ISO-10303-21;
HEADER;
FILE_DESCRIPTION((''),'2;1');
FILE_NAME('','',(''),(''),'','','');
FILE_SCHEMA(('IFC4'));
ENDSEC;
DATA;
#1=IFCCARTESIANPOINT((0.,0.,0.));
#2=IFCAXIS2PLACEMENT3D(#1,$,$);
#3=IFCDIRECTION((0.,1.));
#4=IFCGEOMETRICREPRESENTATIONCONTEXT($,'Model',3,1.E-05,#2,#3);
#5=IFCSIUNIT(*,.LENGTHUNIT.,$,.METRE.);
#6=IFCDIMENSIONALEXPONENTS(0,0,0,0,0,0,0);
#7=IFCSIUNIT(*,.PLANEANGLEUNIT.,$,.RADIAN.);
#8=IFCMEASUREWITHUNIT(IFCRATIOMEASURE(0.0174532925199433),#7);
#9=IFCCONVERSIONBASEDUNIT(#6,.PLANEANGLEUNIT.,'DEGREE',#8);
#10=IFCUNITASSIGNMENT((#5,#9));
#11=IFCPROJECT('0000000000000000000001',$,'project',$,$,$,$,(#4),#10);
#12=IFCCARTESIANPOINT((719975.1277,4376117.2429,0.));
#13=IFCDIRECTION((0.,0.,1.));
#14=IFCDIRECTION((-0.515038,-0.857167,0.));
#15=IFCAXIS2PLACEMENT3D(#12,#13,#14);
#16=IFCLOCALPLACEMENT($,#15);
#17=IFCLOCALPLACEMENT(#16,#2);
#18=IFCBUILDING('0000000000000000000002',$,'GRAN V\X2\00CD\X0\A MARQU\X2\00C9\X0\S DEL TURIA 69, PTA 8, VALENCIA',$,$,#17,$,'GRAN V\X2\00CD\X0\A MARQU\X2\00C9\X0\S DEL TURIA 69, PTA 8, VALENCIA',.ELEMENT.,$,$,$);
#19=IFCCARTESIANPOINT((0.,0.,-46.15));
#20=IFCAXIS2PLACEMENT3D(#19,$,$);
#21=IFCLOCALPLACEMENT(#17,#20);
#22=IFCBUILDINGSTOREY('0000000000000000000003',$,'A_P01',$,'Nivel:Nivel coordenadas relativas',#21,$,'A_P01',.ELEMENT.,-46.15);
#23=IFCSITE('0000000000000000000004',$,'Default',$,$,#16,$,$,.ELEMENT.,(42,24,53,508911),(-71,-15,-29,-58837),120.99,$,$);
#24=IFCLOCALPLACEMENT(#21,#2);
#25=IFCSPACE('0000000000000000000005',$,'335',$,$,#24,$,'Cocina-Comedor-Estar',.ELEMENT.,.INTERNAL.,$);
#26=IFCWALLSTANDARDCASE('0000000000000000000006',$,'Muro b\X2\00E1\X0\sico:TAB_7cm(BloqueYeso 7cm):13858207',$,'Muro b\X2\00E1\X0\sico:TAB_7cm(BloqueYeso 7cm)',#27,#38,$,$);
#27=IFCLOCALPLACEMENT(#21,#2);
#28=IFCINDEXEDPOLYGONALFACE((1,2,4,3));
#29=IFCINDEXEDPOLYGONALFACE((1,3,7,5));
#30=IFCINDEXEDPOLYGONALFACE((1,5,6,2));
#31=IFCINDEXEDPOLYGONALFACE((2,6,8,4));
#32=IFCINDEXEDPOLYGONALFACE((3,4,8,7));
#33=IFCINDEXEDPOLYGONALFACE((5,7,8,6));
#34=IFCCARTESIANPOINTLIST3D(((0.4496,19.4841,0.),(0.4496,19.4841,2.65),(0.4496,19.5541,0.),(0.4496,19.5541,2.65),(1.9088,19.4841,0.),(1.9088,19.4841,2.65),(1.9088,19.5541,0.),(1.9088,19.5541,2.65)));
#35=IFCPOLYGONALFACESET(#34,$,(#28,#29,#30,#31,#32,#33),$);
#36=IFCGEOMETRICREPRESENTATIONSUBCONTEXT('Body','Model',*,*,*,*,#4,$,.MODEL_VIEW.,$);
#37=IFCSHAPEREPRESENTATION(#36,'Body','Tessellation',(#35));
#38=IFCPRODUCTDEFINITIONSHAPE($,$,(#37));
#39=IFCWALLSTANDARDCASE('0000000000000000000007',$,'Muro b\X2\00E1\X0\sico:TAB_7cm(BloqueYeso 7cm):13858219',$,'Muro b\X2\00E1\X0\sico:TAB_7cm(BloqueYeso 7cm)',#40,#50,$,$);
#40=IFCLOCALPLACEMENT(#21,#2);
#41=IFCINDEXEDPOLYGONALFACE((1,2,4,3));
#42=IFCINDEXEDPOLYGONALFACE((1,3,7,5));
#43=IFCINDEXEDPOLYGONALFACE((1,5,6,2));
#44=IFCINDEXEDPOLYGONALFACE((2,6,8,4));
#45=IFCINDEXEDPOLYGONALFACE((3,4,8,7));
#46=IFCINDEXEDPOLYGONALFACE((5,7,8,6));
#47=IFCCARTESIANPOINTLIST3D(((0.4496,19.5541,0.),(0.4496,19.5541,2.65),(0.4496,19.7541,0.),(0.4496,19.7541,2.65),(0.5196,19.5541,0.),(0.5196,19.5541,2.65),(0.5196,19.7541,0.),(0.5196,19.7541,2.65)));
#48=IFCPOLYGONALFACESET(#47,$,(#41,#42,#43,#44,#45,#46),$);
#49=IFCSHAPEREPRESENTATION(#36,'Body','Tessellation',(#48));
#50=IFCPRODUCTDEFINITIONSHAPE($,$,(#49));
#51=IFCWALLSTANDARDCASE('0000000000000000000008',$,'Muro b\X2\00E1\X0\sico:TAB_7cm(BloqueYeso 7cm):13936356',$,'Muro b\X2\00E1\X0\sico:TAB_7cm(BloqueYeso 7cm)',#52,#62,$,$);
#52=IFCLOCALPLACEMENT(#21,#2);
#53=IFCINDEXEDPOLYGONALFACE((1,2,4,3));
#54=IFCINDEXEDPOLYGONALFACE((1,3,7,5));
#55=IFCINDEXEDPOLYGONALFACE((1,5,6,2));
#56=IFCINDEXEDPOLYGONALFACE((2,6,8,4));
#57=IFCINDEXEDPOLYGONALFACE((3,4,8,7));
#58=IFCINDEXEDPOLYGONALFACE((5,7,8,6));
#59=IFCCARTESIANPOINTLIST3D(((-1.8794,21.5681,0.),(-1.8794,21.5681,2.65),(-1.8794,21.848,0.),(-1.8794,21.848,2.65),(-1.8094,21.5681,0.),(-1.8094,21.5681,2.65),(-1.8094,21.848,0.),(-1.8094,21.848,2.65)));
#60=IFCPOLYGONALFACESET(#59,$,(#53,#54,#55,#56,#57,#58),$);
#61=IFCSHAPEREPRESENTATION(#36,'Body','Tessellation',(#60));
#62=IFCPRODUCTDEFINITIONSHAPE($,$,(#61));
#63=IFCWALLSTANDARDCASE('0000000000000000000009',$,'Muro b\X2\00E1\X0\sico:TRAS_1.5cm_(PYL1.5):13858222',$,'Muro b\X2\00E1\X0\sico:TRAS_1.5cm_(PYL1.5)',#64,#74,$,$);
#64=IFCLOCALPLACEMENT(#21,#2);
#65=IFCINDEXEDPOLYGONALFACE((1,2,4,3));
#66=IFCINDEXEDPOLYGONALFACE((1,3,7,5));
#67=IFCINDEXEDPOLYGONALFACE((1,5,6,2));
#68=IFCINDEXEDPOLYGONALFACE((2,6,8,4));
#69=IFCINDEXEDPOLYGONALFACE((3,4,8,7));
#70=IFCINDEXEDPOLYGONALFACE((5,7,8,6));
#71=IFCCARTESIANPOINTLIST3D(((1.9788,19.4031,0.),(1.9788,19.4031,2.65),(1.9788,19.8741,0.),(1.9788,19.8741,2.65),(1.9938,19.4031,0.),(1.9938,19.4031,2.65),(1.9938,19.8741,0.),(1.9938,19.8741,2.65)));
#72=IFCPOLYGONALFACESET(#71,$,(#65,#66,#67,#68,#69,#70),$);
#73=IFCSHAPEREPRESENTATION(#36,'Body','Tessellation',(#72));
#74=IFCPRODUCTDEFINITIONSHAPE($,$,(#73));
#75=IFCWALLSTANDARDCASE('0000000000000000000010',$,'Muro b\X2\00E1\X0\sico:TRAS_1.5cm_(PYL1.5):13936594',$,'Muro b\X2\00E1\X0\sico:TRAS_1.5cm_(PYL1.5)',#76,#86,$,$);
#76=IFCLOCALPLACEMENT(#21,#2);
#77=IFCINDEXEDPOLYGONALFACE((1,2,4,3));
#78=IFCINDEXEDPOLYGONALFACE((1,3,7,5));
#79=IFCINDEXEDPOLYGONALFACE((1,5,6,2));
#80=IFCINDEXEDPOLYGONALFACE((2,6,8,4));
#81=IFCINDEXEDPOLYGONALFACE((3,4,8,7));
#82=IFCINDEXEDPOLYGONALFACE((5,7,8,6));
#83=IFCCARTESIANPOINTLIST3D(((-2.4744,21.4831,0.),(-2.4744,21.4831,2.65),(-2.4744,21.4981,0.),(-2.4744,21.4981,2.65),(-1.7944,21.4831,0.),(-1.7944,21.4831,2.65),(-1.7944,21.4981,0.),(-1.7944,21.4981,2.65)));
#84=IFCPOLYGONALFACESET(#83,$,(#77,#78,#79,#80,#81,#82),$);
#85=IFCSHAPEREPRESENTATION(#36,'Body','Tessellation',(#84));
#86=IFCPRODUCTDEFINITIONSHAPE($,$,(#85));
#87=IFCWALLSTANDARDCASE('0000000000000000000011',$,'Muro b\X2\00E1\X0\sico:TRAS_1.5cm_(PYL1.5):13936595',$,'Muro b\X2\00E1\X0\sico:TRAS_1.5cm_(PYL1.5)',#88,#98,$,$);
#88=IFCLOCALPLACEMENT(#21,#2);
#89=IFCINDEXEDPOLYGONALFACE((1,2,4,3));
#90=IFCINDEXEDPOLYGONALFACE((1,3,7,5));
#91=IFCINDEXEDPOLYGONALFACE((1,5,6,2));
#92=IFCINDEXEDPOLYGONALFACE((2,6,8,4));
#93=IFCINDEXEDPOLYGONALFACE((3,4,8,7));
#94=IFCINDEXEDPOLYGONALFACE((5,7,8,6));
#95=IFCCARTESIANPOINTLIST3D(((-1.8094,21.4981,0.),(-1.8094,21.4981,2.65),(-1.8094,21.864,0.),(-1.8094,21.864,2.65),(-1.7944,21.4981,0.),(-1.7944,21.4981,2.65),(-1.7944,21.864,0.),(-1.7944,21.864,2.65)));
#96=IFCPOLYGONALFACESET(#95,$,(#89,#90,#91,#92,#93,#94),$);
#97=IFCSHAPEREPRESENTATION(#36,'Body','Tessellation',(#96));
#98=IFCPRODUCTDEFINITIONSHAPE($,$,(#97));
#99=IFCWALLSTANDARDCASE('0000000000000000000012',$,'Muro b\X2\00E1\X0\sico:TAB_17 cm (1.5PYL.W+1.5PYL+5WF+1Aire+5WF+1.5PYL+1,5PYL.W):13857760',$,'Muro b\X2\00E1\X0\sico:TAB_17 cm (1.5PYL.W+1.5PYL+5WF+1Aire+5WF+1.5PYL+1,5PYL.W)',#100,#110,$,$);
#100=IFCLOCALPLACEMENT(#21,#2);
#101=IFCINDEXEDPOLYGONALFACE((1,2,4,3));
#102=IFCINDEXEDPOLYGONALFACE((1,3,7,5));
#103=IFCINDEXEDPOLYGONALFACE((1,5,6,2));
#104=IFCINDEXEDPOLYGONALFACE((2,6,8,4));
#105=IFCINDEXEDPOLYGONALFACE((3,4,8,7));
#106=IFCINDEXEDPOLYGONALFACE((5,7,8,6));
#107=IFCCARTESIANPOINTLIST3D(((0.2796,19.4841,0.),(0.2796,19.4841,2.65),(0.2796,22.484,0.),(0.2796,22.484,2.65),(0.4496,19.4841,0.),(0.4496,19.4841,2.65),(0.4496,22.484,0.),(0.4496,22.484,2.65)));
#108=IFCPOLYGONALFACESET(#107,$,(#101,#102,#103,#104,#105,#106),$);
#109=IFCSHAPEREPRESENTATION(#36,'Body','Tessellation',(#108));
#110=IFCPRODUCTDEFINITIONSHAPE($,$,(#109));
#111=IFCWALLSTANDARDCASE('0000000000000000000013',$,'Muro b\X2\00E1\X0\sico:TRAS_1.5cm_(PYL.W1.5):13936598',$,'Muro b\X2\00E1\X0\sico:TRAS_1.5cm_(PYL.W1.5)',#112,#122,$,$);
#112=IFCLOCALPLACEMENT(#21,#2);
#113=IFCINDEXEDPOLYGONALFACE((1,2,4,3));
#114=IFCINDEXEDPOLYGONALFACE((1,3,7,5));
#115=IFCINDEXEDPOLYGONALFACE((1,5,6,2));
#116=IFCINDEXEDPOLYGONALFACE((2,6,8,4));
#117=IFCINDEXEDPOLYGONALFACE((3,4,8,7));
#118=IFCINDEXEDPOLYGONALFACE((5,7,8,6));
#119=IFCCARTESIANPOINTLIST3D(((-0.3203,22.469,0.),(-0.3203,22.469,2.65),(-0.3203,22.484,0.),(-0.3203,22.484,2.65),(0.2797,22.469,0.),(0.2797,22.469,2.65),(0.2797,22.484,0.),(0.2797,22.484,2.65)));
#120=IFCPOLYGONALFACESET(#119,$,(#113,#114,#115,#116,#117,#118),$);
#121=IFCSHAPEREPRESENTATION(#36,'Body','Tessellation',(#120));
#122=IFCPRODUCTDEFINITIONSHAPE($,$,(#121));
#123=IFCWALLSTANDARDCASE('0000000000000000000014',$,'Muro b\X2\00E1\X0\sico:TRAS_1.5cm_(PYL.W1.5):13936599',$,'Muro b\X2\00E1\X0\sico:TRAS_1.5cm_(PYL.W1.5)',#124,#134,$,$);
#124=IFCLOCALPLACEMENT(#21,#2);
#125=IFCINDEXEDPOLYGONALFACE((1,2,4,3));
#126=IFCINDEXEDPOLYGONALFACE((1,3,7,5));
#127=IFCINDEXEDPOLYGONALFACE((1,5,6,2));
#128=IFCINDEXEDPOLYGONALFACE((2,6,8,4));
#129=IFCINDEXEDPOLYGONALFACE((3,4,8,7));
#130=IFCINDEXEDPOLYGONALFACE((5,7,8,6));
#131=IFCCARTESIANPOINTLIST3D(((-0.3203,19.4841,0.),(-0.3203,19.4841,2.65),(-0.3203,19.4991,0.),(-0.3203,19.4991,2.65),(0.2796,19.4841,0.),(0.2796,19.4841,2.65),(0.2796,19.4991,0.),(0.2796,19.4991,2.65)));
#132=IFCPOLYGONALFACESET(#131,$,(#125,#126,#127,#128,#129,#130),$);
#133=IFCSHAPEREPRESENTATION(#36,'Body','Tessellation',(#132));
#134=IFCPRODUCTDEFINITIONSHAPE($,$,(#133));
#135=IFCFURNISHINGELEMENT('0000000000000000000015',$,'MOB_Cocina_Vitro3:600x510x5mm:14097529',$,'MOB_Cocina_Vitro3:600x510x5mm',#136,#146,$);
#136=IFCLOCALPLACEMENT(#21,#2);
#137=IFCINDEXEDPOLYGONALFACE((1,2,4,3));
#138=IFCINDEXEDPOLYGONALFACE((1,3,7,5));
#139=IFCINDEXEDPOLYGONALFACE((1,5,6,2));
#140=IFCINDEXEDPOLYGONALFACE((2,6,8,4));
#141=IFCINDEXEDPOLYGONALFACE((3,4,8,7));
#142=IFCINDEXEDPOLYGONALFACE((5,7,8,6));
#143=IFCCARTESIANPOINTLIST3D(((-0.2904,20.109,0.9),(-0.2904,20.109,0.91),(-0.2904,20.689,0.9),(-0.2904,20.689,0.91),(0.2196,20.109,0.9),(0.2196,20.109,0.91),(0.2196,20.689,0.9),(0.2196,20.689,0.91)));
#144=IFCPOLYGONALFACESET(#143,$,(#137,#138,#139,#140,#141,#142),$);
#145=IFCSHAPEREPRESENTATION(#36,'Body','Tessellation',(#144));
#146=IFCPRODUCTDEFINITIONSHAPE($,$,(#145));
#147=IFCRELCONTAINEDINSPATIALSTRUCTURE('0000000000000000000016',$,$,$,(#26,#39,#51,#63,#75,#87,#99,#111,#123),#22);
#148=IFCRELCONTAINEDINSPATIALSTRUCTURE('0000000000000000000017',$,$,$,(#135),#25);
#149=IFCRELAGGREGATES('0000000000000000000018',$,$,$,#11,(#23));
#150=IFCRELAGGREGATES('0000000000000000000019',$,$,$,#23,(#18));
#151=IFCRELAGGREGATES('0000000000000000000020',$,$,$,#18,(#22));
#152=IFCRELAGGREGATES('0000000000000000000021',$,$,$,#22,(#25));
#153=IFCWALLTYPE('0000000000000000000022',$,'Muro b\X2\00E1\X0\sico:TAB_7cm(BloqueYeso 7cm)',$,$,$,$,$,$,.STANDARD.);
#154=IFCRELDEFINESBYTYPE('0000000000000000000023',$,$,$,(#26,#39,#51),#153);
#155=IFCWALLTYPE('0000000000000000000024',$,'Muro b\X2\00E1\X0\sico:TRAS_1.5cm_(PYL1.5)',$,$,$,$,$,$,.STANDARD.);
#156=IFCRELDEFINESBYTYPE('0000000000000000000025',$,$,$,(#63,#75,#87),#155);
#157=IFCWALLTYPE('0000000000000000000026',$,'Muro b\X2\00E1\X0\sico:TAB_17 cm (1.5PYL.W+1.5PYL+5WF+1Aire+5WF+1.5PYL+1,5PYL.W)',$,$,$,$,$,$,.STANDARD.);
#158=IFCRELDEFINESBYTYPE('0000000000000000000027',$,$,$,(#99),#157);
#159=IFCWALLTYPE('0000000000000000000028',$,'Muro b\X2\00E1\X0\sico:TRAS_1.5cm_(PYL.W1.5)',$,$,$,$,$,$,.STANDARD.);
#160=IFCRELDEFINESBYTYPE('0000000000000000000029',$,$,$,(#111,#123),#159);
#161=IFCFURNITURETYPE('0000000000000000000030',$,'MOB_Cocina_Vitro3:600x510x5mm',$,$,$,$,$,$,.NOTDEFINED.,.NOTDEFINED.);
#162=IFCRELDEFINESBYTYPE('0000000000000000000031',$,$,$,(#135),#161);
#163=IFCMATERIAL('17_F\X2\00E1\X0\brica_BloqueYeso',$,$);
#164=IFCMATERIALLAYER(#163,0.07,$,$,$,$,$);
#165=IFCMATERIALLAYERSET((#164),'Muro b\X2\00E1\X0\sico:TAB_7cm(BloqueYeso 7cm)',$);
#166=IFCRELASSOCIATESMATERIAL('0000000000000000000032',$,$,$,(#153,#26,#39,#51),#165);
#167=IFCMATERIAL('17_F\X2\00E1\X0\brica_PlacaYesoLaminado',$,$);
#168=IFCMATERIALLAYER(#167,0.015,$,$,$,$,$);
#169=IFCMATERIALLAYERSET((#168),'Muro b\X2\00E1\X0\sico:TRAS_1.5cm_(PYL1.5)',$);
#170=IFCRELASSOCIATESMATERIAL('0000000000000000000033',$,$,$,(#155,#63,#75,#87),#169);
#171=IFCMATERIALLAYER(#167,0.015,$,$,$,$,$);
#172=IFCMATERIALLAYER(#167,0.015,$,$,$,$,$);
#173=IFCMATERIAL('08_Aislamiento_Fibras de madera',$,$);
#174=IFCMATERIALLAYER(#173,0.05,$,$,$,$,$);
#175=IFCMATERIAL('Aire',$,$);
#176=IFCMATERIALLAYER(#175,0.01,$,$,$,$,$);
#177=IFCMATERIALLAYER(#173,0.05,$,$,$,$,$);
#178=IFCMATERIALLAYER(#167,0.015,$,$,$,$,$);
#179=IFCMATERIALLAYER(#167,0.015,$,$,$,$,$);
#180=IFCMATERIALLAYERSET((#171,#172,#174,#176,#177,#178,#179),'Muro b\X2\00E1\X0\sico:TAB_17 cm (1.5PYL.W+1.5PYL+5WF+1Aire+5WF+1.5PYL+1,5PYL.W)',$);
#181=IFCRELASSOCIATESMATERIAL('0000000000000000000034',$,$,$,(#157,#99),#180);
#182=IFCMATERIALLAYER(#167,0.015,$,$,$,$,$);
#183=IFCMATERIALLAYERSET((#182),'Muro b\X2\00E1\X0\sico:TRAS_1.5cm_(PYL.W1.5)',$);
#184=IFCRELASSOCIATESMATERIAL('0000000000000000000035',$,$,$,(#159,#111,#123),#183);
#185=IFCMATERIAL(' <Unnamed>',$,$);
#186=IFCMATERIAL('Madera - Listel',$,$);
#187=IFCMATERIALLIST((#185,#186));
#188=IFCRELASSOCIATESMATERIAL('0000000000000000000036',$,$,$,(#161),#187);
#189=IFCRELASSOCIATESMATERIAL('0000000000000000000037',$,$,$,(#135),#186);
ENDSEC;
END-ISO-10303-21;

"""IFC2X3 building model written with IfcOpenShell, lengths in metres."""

from ifc_helpers import new_model, entity, si_unit, converted_unit, direction, frame, frame_2d, origin, origin_2d_with_axis, place, context, subcontext, project, spatial, rectangle, extrude, source, transform, mapped, material, material_list, layer, layer_set, layer_usage, type_object, type_shapes, element, save


model = new_model("IFC2X3")

# Units and contexts
model_context = context("Model", 3, precision=1e-05, world=origin(), true_north=direction((0.0, 1.0)))
body_context = subcontext(model_context, "Body", "Model", "MODEL_VIEW")
ifc_project = project(units=[si_unit("LENGTHUNIT", "METRE"), converted_unit("PLANEANGLEUNIT", "DEGREE", entity("IfcRatioMeasure", 0.0174532925199433), si_unit("PLANEANGLEUNIT", "RADIAN"), dimensions=[0, 0, 0, 0, 0, 0, 0])], contexts=[model_context])

# Site, building, storey
site_placement = place(None, frame((719975.1277, 4376117.2429, 0.0), z_axis=(0.0, 0.0, 1.0), x_axis=(-0.515038, -0.857167, 0.0)))
site = spatial("IfcSite", under=ifc_project, at=site_placement, Name="Default", CompositionType="ELEMENT", RefLatitude=(42, 24, 53, 508911), RefLongitude=(-71, -15, -29, -58837), RefElevation=120.99)
building_placement = place(site_placement, origin())
building = spatial("IfcBuilding", under=site, at=building_placement, Name="GRAN VÍA MARQUÉS DEL TURIA 69, PTA 8, VALENCIA", LongName="GRAN VÍA MARQUÉS DEL TURIA 69, PTA 8, VALENCIA", CompositionType="ELEMENT")
storey_placement = place(building_placement, frame((0.0, 0.0, -46.15)))
storey = spatial("IfcBuildingStorey", under=building, at=storey_placement, Name="A_P01", ObjectType="Nivel:Nivel coordenadas relativas", LongName="A_P01", CompositionType="ELEMENT", Elevation=-46.15)

# Walls
ifc_material_1 = material(Name="17_Fábrica_PlacaYesoLaminado")
ifc_material_2 = material(Name="08_Aislamiento_Fibras de madera")
ifc_material_3 = material(Name="17_Fábrica_BloqueYeso")
ifc_layer_1 = layer(ifc_material_3, 0.07)
ifc_layer_set_1 = layer_set([ifc_layer_1], Name="Muro básico:TAB_7cm(BloqueYeso 7cm)")
wall_type_1 = type_object("IfcWallType", Name="Muro básico:TAB_7cm(BloqueYeso 7cm)", PredefinedType="STANDARD", material=ifc_layer_set_1)
ifc_layer_usage_1 = layer_usage(ifc_layer_set_1, "AXIS2", "NEGATIVE", 0.035)
wall_1_placement = place(storey_placement, frame((0.4496, 19.5191, 0.0)))
element("IfcWallStandardCase", 1, at=wall_1_placement, inside=storey, type_object=wall_type_1, material=ifc_layer_usage_1, Name="Muro básico:TAB_7cm(BloqueYeso 7cm):13858207", ObjectType="Muro básico:TAB_7cm(BloqueYeso 7cm)", context=body_context, shape_type="SweptSolid", body=[
    extrude(rectangle(XDim=1.4592, YDim=0.07, at=frame_2d((0.7296, 0.0), x_axis=(-1.0, 0.0))), origin(), (0.0, 0.0, 1.0), 2.65),
])
ifc_layer_usage_2 = layer_usage(ifc_layer_set_1, "AXIS2", "POSITIVE", -0.035)
wall_2_placement = place(storey_placement, frame((0.4846, 19.5541, 0.0), z_axis=(0.0, 0.0, 1.0), x_axis=(0.0, 1.0, 0.0)))
element("IfcWallStandardCase", 2, at=wall_2_placement, inside=storey, type_object=wall_type_1, material=ifc_layer_usage_2, Name="Muro básico:TAB_7cm(BloqueYeso 7cm):13858219", ObjectType="Muro básico:TAB_7cm(BloqueYeso 7cm)", context=body_context, shape_type="SweptSolid", body=[
    extrude(rectangle(XDim=0.2, YDim=0.07, at=frame_2d((0.1, 0.0), x_axis=(-1.0, 0.0))), origin(), (0.0, 0.0, 1.0), 2.65),
])

# Walls
ifc_layer_usage_3 = layer_usage(ifc_layer_set_1, "AXIS2", "NEGATIVE", 0.035)
wall_3_placement = place(storey_placement, frame((-1.8444, 21.848, 0.0), z_axis=(0.0, 0.0, 1.0), x_axis=(0.0, -1.0, 0.0)))
element("IfcWallStandardCase", 3, at=wall_3_placement, inside=storey, type_object=wall_type_1, material=ifc_layer_usage_3, Name="Muro básico:TAB_7cm(BloqueYeso 7cm):13936356", ObjectType="Muro básico:TAB_7cm(BloqueYeso 7cm)", context=body_context, shape_type="SweptSolid", body=[
    extrude(rectangle(XDim=0.28, YDim=0.07, at=frame_2d((0.14, 0.0), x_axis=(-1.0, 0.0))), origin(), (0.0, 0.0, 1.0), 2.65),
])
ifc_layer_2 = layer(ifc_material_1, 0.015)
ifc_layer_set_2 = layer_set([ifc_layer_2], Name="Muro básico:TRAS_1.5cm_(PYL1.5)")
ifc_layer_usage_4 = layer_usage(ifc_layer_set_2, "AXIS2", "NEGATIVE", 0.0075)
wall_type_2 = type_object("IfcWallType", Name="Muro básico:TRAS_1.5cm_(PYL1.5)", PredefinedType="STANDARD", material=ifc_layer_set_2)
wall_4_placement = place(storey_placement, frame((1.9863, 19.4031, 0.0), z_axis=(0.0, 0.0, 1.0), x_axis=(0.0, 1.0, 0.0)))
element("IfcWallStandardCase", 4, at=wall_4_placement, inside=storey, type_object=wall_type_2, material=ifc_layer_usage_4, Name="Muro básico:TRAS_1.5cm_(PYL1.5):13858222", ObjectType="Muro básico:TRAS_1.5cm_(PYL1.5)", context=body_context, shape_type="SweptSolid", body=[
    extrude(rectangle(XDim=0.471, YDim=0.015, at=frame_2d((0.2355, 0.0), x_axis=(-1.0, 0.0))), origin(), (0.0, 0.0, 1.0), 2.65),
])
ifc_layer_usage_5 = layer_usage(ifc_layer_set_2, "AXIS2", "NEGATIVE", 0.0075)
wall_5_placement = place(storey_placement, frame((-1.7944, 21.4906, 0.0), z_axis=(0.0, 0.0, 1.0), x_axis=(-1.0, 0.0, 0.0)))
element("IfcWallStandardCase", 5, at=wall_5_placement, inside=storey, type_object=wall_type_2, material=ifc_layer_usage_5, Name="Muro básico:TRAS_1.5cm_(PYL1.5):13936594", ObjectType="Muro básico:TRAS_1.5cm_(PYL1.5)", context=body_context, shape_type="SweptSolid", body=[
    extrude(rectangle(XDim=0.68, YDim=0.015, at=frame_2d((0.34, 0.0), x_axis=(-1.0, 0.0))), origin(), (0.0, 0.0, 1.0), 2.65),
])
ifc_layer_usage_6 = layer_usage(ifc_layer_set_2, "AXIS2", "NEGATIVE", 0.0075)
wall_6_placement = place(storey_placement, frame((-1.8019, 21.4981, 0.0), z_axis=(0.0, 0.0, 1.0), x_axis=(0.0, 1.0, 0.0)))
element("IfcWallStandardCase", 6, at=wall_6_placement, inside=storey, type_object=wall_type_2, material=ifc_layer_usage_6, Name="Muro básico:TRAS_1.5cm_(PYL1.5):13936595", ObjectType="Muro básico:TRAS_1.5cm_(PYL1.5)", context=body_context, shape_type="SweptSolid", body=[
    extrude(rectangle(XDim=0.366, YDim=0.015, at=frame_2d((0.183, 0.0), x_axis=(-1.0, 0.0))), origin(), (0.0, 0.0, 1.0), 2.65),
])
ifc_layer_3 = layer(ifc_material_1, 0.015)
ifc_layer_4 = layer(ifc_material_1, 0.015)
ifc_layer_5 = layer(ifc_material_2, 0.05)
ifc_material_4 = material(Name="Aire")
ifc_layer_6 = layer(ifc_material_4, 0.01)
ifc_layer_7 = layer(ifc_material_2, 0.05)
ifc_layer_8 = layer(ifc_material_1, 0.015)
ifc_layer_9 = layer(ifc_material_1, 0.015)
ifc_layer_set_3 = layer_set([ifc_layer_3, ifc_layer_4, ifc_layer_5, ifc_layer_6, ifc_layer_7, ifc_layer_8, ifc_layer_9], Name="Muro básico:TAB_17 cm (1.5PYL.W+1.5PYL+5WF+1Aire+5WF+1.5PYL+1,5PYL.W)")
ifc_layer_usage_7 = layer_usage(ifc_layer_set_3, "AXIS2", "NEGATIVE", 0.085)
wall_type_3 = type_object("IfcWallType", Name="Muro básico:TAB_17 cm (1.5PYL.W+1.5PYL+5WF+1Aire+5WF+1.5PYL+1,5PYL.W)", PredefinedType="STANDARD", material=ifc_layer_set_3)
wall_7_placement = place(storey_placement, frame((0.3646, 22.484, 0.0), z_axis=(0.0, 0.0, 1.0), x_axis=(0.0, -1.0, 0.0)))
element("IfcWallStandardCase", 7, at=wall_7_placement, inside=storey, type_object=wall_type_3, material=ifc_layer_usage_7, Name="Muro básico:TAB_17 cm (1.5PYL.W+1.5PYL+5WF+1Aire+5WF+1.5PYL+1,5PYL.W):13857760", ObjectType="Muro básico:TAB_17 cm (1.5PYL.W+1.5PYL+5WF+1Aire+5WF+1.5PYL+1,5PYL.W)", context=body_context, shape_type="SweptSolid", body=[
    extrude(rectangle(XDim=3.0, YDim=0.17, at=frame_2d((1.5, 0.0), x_axis=(-1.0, 0.0))), origin(), (0.0, 0.0, 1.0), 2.65),
])
ifc_layer_10 = layer(ifc_material_1, 0.015)
ifc_layer_set_4 = layer_set([ifc_layer_10], Name="Muro básico:TRAS_1.5cm_(PYL.W1.5)")
ifc_layer_usage_8 = layer_usage(ifc_layer_set_4, "AXIS2", "NEGATIVE", 0.0075)
wall_type_4 = type_object("IfcWallType", Name="Muro básico:TRAS_1.5cm_(PYL.W1.5)", PredefinedType="STANDARD", material=ifc_layer_set_4)
wall_8_placement = place(storey_placement, frame((-0.3203, 22.4765, 0.0)))
element("IfcWallStandardCase", 8, at=wall_8_placement, inside=storey, type_object=wall_type_4, material=ifc_layer_usage_8, Name="Muro básico:TRAS_1.5cm_(PYL.W1.5):13936598", ObjectType="Muro básico:TRAS_1.5cm_(PYL.W1.5)", context=body_context, shape_type="SweptSolid", body=[
    extrude(rectangle(XDim=0.6, YDim=0.015, at=frame_2d((0.3, 0.0), x_axis=(-1.0, 0.0))), origin(), (0.0, 0.0, 1.0), 2.65),
])
ifc_layer_usage_9 = layer_usage(ifc_layer_set_4, "AXIS2", "NEGATIVE", 0.0075)
wall_9_placement = place(storey_placement, frame((-0.3203, 19.4916, 0.0)))
element("IfcWallStandardCase", 9, at=wall_9_placement, inside=storey, type_object=wall_type_4, material=ifc_layer_usage_9, Name="Muro básico:TRAS_1.5cm_(PYL.W1.5):13936599", ObjectType="Muro básico:TRAS_1.5cm_(PYL.W1.5)", context=body_context, shape_type="SweptSolid", body=[
    extrude(rectangle(XDim=0.5999, YDim=0.015, at=frame_2d((0.3, 0.0), x_axis=(-1.0, 0.0))), origin(), (0.0, 0.0, 1.0), 2.65),
])

# Shared definitions
ifc_material_5 = material(Name=" <Unnamed>")

# Shared definitions
space_1_placement = place(storey_placement, origin())
space_1 = spatial("IfcSpace", under=storey, at=space_1_placement, Name="335", LongName="Cocina-Comedor-Estar", CompositionType="ELEMENT", InteriorOrExteriorSpace="INTERNAL")

# Furnishing element
ifc_material_6 = material(Name="Madera - Listel")
ifc_material_list_1 = material_list([ifc_material_5, ifc_material_6])
furniture_type_1 = type_object("IfcFurnitureType", Name="MOB_Cocina_Vitro3:600x510x5mm", material=ifc_material_list_1)
shared_shape_1 = source(origin(), body_context, "Body", "SweptSolid", [
    extrude(rectangle(XDim=0.51, YDim=0.58, at=origin_2d_with_axis()), frame((0.0, 0.0, 0.0), z_axis=(0.0, 0.0, 1.0), x_axis=(-1.0, 0.0, 0.0)), (0.0, 0.0, 1.0), 0.01),
])
type_shapes(furniture_type_1, [shared_shape_1])
furnishing_1_placement = place(space_1_placement, frame((-0.0354, 20.399, 0.9)))
element("IfcFurnishingElement", 10, at=furnishing_1_placement, inside=space_1, type_object=furniture_type_1, material=ifc_material_6, Name="MOB_Cocina_Vitro3:600x510x5mm:14097529", ObjectType="MOB_Cocina_Vitro3:600x510x5mm", context=body_context, shape_type="MappedRepresentation", body=[
    mapped(shared_shape_1, transform((0.0, 0.0, 0.0), scale=1.0)),
])

save(model, "model.ifc")
